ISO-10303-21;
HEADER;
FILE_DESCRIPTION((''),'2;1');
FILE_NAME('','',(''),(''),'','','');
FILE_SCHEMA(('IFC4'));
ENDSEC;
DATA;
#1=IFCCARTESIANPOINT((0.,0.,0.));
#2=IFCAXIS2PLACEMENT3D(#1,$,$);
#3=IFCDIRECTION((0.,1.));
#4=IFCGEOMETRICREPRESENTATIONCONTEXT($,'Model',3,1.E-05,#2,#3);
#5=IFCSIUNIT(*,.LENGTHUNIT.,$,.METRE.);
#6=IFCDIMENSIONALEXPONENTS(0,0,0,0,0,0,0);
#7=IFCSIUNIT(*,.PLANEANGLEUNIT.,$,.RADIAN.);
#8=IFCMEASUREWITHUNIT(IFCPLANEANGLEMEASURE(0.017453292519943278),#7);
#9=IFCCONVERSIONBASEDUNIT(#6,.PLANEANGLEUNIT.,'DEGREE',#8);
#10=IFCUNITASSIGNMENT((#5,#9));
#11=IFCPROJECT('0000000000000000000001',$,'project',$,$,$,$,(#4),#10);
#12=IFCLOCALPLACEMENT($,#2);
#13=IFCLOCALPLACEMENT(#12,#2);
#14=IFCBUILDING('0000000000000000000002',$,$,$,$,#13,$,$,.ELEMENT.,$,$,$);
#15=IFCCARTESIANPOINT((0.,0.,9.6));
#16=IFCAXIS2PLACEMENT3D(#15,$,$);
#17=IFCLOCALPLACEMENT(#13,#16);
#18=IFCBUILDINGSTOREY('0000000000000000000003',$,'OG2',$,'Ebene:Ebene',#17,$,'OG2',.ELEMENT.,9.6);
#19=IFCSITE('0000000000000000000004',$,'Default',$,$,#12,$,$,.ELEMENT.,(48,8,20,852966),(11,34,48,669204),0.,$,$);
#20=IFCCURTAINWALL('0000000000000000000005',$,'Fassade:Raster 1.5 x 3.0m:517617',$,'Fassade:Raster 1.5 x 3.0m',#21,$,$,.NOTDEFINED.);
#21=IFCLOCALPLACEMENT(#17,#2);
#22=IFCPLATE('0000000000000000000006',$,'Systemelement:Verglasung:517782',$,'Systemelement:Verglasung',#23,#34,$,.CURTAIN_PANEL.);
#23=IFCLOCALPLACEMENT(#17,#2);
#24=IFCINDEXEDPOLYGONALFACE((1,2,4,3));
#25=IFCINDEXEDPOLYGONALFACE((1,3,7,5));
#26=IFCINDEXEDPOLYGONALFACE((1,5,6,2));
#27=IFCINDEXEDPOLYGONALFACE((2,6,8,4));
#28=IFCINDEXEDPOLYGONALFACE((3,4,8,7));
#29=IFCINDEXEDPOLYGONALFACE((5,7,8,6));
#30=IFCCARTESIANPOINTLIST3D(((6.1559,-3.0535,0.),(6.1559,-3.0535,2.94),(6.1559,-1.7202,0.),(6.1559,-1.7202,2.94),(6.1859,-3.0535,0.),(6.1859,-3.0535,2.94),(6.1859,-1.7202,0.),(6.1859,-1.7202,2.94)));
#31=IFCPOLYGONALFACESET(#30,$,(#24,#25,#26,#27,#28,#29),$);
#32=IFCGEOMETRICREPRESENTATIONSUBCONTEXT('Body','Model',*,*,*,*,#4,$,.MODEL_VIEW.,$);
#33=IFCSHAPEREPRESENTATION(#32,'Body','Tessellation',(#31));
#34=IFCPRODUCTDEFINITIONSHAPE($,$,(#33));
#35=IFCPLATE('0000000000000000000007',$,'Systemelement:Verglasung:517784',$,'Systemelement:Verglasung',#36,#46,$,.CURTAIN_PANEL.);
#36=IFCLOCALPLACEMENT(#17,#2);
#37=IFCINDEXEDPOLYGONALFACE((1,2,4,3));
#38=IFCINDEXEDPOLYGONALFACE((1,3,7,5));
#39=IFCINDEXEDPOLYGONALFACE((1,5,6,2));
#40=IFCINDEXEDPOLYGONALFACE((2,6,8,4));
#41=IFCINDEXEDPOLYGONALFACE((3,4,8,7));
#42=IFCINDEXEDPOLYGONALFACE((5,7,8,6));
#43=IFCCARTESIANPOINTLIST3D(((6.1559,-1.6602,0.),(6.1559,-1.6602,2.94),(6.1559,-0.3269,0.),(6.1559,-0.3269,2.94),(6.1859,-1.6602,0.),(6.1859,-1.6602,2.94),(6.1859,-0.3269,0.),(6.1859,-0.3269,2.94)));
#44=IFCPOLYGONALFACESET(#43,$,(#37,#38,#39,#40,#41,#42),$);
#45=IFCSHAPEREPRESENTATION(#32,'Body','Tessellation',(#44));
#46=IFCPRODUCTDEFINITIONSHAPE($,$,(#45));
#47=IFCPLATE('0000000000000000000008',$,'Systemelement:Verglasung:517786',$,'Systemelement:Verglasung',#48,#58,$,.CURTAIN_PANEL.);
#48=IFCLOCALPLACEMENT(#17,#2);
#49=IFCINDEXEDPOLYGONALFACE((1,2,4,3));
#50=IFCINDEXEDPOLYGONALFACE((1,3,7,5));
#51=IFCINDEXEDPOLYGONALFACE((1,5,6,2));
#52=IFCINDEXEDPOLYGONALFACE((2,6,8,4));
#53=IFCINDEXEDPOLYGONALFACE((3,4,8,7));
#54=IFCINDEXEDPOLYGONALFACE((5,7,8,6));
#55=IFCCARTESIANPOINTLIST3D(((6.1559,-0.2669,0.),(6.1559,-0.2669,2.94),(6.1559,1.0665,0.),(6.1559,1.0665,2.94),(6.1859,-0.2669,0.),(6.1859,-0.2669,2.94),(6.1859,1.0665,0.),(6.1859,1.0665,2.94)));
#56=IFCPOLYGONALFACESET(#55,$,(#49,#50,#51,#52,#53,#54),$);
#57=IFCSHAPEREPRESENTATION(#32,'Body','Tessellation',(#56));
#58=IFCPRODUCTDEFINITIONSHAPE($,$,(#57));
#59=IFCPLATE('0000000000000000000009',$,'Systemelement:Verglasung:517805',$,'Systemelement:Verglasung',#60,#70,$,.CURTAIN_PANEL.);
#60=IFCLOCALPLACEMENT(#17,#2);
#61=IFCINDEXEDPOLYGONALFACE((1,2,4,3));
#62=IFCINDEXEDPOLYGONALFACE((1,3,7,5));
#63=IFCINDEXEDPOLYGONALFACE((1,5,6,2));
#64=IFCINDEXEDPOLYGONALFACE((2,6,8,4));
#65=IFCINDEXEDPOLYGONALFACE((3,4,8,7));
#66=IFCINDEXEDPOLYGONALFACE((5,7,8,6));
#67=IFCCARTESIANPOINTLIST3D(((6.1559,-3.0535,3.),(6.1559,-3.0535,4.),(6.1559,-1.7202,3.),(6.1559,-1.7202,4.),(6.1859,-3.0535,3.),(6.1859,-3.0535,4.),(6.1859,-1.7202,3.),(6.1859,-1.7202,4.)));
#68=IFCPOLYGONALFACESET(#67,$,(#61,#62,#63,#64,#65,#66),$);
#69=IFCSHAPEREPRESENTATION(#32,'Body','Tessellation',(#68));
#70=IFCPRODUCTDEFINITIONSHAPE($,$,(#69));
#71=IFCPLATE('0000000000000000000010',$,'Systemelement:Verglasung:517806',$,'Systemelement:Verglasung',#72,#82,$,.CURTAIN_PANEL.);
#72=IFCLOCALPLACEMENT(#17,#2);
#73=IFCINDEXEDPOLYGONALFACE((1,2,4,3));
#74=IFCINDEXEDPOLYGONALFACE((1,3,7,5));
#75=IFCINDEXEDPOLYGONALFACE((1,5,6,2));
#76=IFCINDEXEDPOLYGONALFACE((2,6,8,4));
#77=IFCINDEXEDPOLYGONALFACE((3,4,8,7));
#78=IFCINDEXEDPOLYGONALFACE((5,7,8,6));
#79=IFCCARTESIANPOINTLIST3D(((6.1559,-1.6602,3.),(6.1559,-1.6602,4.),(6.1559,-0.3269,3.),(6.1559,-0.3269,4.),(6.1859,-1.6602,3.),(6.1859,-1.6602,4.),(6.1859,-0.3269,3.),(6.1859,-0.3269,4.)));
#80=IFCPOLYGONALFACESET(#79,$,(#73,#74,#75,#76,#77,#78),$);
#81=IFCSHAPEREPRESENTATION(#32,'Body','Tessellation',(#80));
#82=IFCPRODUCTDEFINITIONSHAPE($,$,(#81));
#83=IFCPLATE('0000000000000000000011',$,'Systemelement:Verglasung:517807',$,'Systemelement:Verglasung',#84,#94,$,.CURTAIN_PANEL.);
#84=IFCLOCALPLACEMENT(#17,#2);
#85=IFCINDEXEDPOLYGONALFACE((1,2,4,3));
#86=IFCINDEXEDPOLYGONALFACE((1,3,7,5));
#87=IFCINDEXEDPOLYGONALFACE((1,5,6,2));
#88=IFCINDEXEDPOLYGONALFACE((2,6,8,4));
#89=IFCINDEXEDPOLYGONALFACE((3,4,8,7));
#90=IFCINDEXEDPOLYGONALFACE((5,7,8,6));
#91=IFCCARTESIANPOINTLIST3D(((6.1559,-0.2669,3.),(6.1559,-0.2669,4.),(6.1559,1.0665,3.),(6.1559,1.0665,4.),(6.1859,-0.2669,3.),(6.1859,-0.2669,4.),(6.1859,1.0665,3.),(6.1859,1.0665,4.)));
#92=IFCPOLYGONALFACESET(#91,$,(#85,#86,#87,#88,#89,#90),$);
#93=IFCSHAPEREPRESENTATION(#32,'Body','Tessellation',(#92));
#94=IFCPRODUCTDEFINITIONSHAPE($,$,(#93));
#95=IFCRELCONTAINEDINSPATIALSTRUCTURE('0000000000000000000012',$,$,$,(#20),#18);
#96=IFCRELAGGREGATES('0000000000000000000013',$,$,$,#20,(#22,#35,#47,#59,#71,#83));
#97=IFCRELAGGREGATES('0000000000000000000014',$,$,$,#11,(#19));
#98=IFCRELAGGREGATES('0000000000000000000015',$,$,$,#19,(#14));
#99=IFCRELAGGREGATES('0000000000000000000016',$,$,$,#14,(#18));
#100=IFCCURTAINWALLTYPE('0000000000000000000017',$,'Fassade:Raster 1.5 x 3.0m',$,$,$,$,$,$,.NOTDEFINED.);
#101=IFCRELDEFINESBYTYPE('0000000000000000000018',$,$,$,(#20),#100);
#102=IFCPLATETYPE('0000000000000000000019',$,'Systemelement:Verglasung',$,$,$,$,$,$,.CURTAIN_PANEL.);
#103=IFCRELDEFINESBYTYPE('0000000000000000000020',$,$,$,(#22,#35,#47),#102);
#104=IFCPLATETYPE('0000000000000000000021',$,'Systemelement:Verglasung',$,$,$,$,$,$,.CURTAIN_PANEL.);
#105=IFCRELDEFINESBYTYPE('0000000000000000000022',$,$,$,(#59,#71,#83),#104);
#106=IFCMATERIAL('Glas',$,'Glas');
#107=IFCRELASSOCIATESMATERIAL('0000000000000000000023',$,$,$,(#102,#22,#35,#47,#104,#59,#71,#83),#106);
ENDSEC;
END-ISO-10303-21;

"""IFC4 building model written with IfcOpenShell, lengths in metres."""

from ifc_helpers import new_model, entity, si_unit, converted_unit, direction, frame, origin, place, context, subcontext, project, spatial, indexed_curve, outline, extrude, source, transform, mapped, material, type_object, type_shapes, element, aggregate, save


model = new_model("IFC4")

# Units and contexts
model_context = context("Model", 3, precision=1e-05, world=origin(), true_north=direction((0.0, 1.0)))
body_context = subcontext(model_context, "Body", "Model", "MODEL_VIEW")
ifc_project = project(units=[si_unit("LENGTHUNIT", "METRE"), converted_unit("PLANEANGLEUNIT", "DEGREE", entity("IfcPlaneAngleMeasure", 0.017453292519943278), si_unit("PLANEANGLEUNIT", "RADIAN"), dimensions=[0, 0, 0, 0, 0, 0, 0])], contexts=[model_context])

# Site, building, storey
site_placement = place(None, origin())
site = spatial("IfcSite", under=ifc_project, at=site_placement, Name="Default", CompositionType="ELEMENT", RefLatitude=(48, 8, 20, 852966), RefLongitude=(11, 34, 48, 669204), RefElevation=0.0)
building_placement = place(site_placement, origin())
building = spatial("IfcBuilding", under=site, at=building_placement, CompositionType="ELEMENT")
storey_placement = place(building_placement, frame((0.0, 0.0, 9.6)))
storey = spatial("IfcBuildingStorey", under=building, at=storey_placement, Name="OG2", ObjectType="Ebene:Ebene", LongName="OG2", CompositionType="ELEMENT", Elevation=9.6)

# Curtain wall
curtain_wall_type = type_object("IfcCurtainWallType", Name="Fassade:Raster 1.5 x 3.0m", PredefinedType="NOTDEFINED")
curtain_wall_placement = place(storey_placement, frame((0.0, 0.0, -9.6)))
curtain_wall = element("IfcCurtainWall", 1, at=curtain_wall_placement, inside=storey, type_object=curtain_wall_type, Name="Fassade:Raster 1.5 x 3.0m:517617", ObjectType="Fassade:Raster 1.5 x 3.0m", PredefinedType="NOTDEFINED")

# Plates
ifc_material_1 = material(Name="Glas", Category="Glas")
plate_type_1 = type_object("IfcPlateType", Name="Systemelement:Verglasung", PredefinedType="CURTAIN_PANEL", material=ifc_material_1)
shared_shape_1 = source(origin(), body_context, "Body", "SweptSolid", [
    extrude(outline(indexed_curve([(-0.015, -0.6667), (0.015, -0.6667), (0.015, 0.6667), (-0.015, 0.6667), (-0.015, -0.6667)], self_intersect=False)), frame((0.0, 0.0, 0.0), z_axis=(0.0, 0.0, 1.0), x_axis=(0.0, 1.0, 0.0)), (0.0, 0.0, 1.0), 2.94),
])
type_shapes(plate_type_1, [shared_shape_1])
plate_1_placement = place(curtain_wall_placement, frame((6.1709, -2.3869, 9.6), z_axis=(0.0, 0.0, 1.0), x_axis=(0.0, 1.0, 0.0)))
plate_1 = element("IfcPlate", 2, at=plate_1_placement, type_object=plate_type_1, material=ifc_material_1, Name="Systemelement:Verglasung:517782", ObjectType="Systemelement:Verglasung", PredefinedType="CURTAIN_PANEL", context=body_context, shape_type="MappedRepresentation", body=[
    mapped(shared_shape_1, transform((0.0, 0.0, 0.0), scale=1.0)),
])
plate_2_placement = place(curtain_wall_placement, frame((6.1709, -0.9935, 9.6), z_axis=(0.0, 0.0, 1.0), x_axis=(0.0, 1.0, 0.0)))
plate_2 = element("IfcPlate", 3, at=plate_2_placement, type_object=plate_type_1, material=ifc_material_1, Name="Systemelement:Verglasung:517784", ObjectType="Systemelement:Verglasung", PredefinedType="CURTAIN_PANEL", context=body_context, shape_type="MappedRepresentation", body=[
    mapped(shared_shape_1, transform((0.0, 0.0, 0.0), scale=1.0)),
])
plate_3_placement = place(curtain_wall_placement, frame((6.1709, 0.3998, 9.6), z_axis=(0.0, 0.0, 1.0), x_axis=(0.0, 1.0, 0.0)))
plate_3 = element("IfcPlate", 4, at=plate_3_placement, type_object=plate_type_1, material=ifc_material_1, Name="Systemelement:Verglasung:517786", ObjectType="Systemelement:Verglasung", PredefinedType="CURTAIN_PANEL", context=body_context, shape_type="MappedRepresentation", body=[
    mapped(shared_shape_1, transform((0.0, 0.0, 0.0), scale=1.0)),
])
plate_type_2 = type_object("IfcPlateType", Name="Systemelement:Verglasung", PredefinedType="CURTAIN_PANEL", material=ifc_material_1)
shared_shape_2 = source(origin(), body_context, "Body", "SweptSolid", [
    extrude(outline(indexed_curve([(-0.015, -0.6667), (0.015, -0.6667), (0.015, 0.6667), (-0.015, 0.6667), (-0.015, -0.6667)], self_intersect=False)), frame((0.0, 0.0, 0.0), z_axis=(0.0, 0.0, 1.0), x_axis=(0.0, 1.0, 0.0)), (0.0, 0.0, 1.0), 1.0),
])
type_shapes(plate_type_2, [shared_shape_2])
plate_4_placement = place(curtain_wall_placement, frame((6.1709, -2.3869, 12.6), z_axis=(0.0, 0.0, 1.0), x_axis=(0.0, 1.0, 0.0)))
plate_4 = element("IfcPlate", 5, at=plate_4_placement, type_object=plate_type_2, material=ifc_material_1, Name="Systemelement:Verglasung:517805", ObjectType="Systemelement:Verglasung", PredefinedType="CURTAIN_PANEL", context=body_context, shape_type="MappedRepresentation", body=[
    mapped(shared_shape_2, transform((0.0, 0.0, 0.0), scale=1.0)),
])
plate_5_placement = place(curtain_wall_placement, frame((6.1709, -0.9935, 12.6), z_axis=(0.0, 0.0, 1.0), x_axis=(0.0, 1.0, 0.0)))
plate_5 = element("IfcPlate", 6, at=plate_5_placement, type_object=plate_type_2, material=ifc_material_1, Name="Systemelement:Verglasung:517806", ObjectType="Systemelement:Verglasung", PredefinedType="CURTAIN_PANEL", context=body_context, shape_type="MappedRepresentation", body=[
    mapped(shared_shape_2, transform((0.0, 0.0, 0.0), scale=1.0)),
])
plate_6_placement = place(curtain_wall_placement, frame((6.1709, 0.3998, 12.6), z_axis=(0.0, 0.0, 1.0), x_axis=(0.0, 1.0, 0.0)))
plate_6 = element("IfcPlate", 7, at=plate_6_placement, type_object=plate_type_2, material=ifc_material_1, Name="Systemelement:Verglasung:517807", ObjectType="Systemelement:Verglasung", PredefinedType="CURTAIN_PANEL", context=body_context, shape_type="MappedRepresentation", body=[
    mapped(shared_shape_2, transform((0.0, 0.0, 0.0), scale=1.0)),
])
aggregate(curtain_wall, [plate_1, plate_2, plate_3, plate_4, plate_5, plate_6])

save(model, "model.ifc")
